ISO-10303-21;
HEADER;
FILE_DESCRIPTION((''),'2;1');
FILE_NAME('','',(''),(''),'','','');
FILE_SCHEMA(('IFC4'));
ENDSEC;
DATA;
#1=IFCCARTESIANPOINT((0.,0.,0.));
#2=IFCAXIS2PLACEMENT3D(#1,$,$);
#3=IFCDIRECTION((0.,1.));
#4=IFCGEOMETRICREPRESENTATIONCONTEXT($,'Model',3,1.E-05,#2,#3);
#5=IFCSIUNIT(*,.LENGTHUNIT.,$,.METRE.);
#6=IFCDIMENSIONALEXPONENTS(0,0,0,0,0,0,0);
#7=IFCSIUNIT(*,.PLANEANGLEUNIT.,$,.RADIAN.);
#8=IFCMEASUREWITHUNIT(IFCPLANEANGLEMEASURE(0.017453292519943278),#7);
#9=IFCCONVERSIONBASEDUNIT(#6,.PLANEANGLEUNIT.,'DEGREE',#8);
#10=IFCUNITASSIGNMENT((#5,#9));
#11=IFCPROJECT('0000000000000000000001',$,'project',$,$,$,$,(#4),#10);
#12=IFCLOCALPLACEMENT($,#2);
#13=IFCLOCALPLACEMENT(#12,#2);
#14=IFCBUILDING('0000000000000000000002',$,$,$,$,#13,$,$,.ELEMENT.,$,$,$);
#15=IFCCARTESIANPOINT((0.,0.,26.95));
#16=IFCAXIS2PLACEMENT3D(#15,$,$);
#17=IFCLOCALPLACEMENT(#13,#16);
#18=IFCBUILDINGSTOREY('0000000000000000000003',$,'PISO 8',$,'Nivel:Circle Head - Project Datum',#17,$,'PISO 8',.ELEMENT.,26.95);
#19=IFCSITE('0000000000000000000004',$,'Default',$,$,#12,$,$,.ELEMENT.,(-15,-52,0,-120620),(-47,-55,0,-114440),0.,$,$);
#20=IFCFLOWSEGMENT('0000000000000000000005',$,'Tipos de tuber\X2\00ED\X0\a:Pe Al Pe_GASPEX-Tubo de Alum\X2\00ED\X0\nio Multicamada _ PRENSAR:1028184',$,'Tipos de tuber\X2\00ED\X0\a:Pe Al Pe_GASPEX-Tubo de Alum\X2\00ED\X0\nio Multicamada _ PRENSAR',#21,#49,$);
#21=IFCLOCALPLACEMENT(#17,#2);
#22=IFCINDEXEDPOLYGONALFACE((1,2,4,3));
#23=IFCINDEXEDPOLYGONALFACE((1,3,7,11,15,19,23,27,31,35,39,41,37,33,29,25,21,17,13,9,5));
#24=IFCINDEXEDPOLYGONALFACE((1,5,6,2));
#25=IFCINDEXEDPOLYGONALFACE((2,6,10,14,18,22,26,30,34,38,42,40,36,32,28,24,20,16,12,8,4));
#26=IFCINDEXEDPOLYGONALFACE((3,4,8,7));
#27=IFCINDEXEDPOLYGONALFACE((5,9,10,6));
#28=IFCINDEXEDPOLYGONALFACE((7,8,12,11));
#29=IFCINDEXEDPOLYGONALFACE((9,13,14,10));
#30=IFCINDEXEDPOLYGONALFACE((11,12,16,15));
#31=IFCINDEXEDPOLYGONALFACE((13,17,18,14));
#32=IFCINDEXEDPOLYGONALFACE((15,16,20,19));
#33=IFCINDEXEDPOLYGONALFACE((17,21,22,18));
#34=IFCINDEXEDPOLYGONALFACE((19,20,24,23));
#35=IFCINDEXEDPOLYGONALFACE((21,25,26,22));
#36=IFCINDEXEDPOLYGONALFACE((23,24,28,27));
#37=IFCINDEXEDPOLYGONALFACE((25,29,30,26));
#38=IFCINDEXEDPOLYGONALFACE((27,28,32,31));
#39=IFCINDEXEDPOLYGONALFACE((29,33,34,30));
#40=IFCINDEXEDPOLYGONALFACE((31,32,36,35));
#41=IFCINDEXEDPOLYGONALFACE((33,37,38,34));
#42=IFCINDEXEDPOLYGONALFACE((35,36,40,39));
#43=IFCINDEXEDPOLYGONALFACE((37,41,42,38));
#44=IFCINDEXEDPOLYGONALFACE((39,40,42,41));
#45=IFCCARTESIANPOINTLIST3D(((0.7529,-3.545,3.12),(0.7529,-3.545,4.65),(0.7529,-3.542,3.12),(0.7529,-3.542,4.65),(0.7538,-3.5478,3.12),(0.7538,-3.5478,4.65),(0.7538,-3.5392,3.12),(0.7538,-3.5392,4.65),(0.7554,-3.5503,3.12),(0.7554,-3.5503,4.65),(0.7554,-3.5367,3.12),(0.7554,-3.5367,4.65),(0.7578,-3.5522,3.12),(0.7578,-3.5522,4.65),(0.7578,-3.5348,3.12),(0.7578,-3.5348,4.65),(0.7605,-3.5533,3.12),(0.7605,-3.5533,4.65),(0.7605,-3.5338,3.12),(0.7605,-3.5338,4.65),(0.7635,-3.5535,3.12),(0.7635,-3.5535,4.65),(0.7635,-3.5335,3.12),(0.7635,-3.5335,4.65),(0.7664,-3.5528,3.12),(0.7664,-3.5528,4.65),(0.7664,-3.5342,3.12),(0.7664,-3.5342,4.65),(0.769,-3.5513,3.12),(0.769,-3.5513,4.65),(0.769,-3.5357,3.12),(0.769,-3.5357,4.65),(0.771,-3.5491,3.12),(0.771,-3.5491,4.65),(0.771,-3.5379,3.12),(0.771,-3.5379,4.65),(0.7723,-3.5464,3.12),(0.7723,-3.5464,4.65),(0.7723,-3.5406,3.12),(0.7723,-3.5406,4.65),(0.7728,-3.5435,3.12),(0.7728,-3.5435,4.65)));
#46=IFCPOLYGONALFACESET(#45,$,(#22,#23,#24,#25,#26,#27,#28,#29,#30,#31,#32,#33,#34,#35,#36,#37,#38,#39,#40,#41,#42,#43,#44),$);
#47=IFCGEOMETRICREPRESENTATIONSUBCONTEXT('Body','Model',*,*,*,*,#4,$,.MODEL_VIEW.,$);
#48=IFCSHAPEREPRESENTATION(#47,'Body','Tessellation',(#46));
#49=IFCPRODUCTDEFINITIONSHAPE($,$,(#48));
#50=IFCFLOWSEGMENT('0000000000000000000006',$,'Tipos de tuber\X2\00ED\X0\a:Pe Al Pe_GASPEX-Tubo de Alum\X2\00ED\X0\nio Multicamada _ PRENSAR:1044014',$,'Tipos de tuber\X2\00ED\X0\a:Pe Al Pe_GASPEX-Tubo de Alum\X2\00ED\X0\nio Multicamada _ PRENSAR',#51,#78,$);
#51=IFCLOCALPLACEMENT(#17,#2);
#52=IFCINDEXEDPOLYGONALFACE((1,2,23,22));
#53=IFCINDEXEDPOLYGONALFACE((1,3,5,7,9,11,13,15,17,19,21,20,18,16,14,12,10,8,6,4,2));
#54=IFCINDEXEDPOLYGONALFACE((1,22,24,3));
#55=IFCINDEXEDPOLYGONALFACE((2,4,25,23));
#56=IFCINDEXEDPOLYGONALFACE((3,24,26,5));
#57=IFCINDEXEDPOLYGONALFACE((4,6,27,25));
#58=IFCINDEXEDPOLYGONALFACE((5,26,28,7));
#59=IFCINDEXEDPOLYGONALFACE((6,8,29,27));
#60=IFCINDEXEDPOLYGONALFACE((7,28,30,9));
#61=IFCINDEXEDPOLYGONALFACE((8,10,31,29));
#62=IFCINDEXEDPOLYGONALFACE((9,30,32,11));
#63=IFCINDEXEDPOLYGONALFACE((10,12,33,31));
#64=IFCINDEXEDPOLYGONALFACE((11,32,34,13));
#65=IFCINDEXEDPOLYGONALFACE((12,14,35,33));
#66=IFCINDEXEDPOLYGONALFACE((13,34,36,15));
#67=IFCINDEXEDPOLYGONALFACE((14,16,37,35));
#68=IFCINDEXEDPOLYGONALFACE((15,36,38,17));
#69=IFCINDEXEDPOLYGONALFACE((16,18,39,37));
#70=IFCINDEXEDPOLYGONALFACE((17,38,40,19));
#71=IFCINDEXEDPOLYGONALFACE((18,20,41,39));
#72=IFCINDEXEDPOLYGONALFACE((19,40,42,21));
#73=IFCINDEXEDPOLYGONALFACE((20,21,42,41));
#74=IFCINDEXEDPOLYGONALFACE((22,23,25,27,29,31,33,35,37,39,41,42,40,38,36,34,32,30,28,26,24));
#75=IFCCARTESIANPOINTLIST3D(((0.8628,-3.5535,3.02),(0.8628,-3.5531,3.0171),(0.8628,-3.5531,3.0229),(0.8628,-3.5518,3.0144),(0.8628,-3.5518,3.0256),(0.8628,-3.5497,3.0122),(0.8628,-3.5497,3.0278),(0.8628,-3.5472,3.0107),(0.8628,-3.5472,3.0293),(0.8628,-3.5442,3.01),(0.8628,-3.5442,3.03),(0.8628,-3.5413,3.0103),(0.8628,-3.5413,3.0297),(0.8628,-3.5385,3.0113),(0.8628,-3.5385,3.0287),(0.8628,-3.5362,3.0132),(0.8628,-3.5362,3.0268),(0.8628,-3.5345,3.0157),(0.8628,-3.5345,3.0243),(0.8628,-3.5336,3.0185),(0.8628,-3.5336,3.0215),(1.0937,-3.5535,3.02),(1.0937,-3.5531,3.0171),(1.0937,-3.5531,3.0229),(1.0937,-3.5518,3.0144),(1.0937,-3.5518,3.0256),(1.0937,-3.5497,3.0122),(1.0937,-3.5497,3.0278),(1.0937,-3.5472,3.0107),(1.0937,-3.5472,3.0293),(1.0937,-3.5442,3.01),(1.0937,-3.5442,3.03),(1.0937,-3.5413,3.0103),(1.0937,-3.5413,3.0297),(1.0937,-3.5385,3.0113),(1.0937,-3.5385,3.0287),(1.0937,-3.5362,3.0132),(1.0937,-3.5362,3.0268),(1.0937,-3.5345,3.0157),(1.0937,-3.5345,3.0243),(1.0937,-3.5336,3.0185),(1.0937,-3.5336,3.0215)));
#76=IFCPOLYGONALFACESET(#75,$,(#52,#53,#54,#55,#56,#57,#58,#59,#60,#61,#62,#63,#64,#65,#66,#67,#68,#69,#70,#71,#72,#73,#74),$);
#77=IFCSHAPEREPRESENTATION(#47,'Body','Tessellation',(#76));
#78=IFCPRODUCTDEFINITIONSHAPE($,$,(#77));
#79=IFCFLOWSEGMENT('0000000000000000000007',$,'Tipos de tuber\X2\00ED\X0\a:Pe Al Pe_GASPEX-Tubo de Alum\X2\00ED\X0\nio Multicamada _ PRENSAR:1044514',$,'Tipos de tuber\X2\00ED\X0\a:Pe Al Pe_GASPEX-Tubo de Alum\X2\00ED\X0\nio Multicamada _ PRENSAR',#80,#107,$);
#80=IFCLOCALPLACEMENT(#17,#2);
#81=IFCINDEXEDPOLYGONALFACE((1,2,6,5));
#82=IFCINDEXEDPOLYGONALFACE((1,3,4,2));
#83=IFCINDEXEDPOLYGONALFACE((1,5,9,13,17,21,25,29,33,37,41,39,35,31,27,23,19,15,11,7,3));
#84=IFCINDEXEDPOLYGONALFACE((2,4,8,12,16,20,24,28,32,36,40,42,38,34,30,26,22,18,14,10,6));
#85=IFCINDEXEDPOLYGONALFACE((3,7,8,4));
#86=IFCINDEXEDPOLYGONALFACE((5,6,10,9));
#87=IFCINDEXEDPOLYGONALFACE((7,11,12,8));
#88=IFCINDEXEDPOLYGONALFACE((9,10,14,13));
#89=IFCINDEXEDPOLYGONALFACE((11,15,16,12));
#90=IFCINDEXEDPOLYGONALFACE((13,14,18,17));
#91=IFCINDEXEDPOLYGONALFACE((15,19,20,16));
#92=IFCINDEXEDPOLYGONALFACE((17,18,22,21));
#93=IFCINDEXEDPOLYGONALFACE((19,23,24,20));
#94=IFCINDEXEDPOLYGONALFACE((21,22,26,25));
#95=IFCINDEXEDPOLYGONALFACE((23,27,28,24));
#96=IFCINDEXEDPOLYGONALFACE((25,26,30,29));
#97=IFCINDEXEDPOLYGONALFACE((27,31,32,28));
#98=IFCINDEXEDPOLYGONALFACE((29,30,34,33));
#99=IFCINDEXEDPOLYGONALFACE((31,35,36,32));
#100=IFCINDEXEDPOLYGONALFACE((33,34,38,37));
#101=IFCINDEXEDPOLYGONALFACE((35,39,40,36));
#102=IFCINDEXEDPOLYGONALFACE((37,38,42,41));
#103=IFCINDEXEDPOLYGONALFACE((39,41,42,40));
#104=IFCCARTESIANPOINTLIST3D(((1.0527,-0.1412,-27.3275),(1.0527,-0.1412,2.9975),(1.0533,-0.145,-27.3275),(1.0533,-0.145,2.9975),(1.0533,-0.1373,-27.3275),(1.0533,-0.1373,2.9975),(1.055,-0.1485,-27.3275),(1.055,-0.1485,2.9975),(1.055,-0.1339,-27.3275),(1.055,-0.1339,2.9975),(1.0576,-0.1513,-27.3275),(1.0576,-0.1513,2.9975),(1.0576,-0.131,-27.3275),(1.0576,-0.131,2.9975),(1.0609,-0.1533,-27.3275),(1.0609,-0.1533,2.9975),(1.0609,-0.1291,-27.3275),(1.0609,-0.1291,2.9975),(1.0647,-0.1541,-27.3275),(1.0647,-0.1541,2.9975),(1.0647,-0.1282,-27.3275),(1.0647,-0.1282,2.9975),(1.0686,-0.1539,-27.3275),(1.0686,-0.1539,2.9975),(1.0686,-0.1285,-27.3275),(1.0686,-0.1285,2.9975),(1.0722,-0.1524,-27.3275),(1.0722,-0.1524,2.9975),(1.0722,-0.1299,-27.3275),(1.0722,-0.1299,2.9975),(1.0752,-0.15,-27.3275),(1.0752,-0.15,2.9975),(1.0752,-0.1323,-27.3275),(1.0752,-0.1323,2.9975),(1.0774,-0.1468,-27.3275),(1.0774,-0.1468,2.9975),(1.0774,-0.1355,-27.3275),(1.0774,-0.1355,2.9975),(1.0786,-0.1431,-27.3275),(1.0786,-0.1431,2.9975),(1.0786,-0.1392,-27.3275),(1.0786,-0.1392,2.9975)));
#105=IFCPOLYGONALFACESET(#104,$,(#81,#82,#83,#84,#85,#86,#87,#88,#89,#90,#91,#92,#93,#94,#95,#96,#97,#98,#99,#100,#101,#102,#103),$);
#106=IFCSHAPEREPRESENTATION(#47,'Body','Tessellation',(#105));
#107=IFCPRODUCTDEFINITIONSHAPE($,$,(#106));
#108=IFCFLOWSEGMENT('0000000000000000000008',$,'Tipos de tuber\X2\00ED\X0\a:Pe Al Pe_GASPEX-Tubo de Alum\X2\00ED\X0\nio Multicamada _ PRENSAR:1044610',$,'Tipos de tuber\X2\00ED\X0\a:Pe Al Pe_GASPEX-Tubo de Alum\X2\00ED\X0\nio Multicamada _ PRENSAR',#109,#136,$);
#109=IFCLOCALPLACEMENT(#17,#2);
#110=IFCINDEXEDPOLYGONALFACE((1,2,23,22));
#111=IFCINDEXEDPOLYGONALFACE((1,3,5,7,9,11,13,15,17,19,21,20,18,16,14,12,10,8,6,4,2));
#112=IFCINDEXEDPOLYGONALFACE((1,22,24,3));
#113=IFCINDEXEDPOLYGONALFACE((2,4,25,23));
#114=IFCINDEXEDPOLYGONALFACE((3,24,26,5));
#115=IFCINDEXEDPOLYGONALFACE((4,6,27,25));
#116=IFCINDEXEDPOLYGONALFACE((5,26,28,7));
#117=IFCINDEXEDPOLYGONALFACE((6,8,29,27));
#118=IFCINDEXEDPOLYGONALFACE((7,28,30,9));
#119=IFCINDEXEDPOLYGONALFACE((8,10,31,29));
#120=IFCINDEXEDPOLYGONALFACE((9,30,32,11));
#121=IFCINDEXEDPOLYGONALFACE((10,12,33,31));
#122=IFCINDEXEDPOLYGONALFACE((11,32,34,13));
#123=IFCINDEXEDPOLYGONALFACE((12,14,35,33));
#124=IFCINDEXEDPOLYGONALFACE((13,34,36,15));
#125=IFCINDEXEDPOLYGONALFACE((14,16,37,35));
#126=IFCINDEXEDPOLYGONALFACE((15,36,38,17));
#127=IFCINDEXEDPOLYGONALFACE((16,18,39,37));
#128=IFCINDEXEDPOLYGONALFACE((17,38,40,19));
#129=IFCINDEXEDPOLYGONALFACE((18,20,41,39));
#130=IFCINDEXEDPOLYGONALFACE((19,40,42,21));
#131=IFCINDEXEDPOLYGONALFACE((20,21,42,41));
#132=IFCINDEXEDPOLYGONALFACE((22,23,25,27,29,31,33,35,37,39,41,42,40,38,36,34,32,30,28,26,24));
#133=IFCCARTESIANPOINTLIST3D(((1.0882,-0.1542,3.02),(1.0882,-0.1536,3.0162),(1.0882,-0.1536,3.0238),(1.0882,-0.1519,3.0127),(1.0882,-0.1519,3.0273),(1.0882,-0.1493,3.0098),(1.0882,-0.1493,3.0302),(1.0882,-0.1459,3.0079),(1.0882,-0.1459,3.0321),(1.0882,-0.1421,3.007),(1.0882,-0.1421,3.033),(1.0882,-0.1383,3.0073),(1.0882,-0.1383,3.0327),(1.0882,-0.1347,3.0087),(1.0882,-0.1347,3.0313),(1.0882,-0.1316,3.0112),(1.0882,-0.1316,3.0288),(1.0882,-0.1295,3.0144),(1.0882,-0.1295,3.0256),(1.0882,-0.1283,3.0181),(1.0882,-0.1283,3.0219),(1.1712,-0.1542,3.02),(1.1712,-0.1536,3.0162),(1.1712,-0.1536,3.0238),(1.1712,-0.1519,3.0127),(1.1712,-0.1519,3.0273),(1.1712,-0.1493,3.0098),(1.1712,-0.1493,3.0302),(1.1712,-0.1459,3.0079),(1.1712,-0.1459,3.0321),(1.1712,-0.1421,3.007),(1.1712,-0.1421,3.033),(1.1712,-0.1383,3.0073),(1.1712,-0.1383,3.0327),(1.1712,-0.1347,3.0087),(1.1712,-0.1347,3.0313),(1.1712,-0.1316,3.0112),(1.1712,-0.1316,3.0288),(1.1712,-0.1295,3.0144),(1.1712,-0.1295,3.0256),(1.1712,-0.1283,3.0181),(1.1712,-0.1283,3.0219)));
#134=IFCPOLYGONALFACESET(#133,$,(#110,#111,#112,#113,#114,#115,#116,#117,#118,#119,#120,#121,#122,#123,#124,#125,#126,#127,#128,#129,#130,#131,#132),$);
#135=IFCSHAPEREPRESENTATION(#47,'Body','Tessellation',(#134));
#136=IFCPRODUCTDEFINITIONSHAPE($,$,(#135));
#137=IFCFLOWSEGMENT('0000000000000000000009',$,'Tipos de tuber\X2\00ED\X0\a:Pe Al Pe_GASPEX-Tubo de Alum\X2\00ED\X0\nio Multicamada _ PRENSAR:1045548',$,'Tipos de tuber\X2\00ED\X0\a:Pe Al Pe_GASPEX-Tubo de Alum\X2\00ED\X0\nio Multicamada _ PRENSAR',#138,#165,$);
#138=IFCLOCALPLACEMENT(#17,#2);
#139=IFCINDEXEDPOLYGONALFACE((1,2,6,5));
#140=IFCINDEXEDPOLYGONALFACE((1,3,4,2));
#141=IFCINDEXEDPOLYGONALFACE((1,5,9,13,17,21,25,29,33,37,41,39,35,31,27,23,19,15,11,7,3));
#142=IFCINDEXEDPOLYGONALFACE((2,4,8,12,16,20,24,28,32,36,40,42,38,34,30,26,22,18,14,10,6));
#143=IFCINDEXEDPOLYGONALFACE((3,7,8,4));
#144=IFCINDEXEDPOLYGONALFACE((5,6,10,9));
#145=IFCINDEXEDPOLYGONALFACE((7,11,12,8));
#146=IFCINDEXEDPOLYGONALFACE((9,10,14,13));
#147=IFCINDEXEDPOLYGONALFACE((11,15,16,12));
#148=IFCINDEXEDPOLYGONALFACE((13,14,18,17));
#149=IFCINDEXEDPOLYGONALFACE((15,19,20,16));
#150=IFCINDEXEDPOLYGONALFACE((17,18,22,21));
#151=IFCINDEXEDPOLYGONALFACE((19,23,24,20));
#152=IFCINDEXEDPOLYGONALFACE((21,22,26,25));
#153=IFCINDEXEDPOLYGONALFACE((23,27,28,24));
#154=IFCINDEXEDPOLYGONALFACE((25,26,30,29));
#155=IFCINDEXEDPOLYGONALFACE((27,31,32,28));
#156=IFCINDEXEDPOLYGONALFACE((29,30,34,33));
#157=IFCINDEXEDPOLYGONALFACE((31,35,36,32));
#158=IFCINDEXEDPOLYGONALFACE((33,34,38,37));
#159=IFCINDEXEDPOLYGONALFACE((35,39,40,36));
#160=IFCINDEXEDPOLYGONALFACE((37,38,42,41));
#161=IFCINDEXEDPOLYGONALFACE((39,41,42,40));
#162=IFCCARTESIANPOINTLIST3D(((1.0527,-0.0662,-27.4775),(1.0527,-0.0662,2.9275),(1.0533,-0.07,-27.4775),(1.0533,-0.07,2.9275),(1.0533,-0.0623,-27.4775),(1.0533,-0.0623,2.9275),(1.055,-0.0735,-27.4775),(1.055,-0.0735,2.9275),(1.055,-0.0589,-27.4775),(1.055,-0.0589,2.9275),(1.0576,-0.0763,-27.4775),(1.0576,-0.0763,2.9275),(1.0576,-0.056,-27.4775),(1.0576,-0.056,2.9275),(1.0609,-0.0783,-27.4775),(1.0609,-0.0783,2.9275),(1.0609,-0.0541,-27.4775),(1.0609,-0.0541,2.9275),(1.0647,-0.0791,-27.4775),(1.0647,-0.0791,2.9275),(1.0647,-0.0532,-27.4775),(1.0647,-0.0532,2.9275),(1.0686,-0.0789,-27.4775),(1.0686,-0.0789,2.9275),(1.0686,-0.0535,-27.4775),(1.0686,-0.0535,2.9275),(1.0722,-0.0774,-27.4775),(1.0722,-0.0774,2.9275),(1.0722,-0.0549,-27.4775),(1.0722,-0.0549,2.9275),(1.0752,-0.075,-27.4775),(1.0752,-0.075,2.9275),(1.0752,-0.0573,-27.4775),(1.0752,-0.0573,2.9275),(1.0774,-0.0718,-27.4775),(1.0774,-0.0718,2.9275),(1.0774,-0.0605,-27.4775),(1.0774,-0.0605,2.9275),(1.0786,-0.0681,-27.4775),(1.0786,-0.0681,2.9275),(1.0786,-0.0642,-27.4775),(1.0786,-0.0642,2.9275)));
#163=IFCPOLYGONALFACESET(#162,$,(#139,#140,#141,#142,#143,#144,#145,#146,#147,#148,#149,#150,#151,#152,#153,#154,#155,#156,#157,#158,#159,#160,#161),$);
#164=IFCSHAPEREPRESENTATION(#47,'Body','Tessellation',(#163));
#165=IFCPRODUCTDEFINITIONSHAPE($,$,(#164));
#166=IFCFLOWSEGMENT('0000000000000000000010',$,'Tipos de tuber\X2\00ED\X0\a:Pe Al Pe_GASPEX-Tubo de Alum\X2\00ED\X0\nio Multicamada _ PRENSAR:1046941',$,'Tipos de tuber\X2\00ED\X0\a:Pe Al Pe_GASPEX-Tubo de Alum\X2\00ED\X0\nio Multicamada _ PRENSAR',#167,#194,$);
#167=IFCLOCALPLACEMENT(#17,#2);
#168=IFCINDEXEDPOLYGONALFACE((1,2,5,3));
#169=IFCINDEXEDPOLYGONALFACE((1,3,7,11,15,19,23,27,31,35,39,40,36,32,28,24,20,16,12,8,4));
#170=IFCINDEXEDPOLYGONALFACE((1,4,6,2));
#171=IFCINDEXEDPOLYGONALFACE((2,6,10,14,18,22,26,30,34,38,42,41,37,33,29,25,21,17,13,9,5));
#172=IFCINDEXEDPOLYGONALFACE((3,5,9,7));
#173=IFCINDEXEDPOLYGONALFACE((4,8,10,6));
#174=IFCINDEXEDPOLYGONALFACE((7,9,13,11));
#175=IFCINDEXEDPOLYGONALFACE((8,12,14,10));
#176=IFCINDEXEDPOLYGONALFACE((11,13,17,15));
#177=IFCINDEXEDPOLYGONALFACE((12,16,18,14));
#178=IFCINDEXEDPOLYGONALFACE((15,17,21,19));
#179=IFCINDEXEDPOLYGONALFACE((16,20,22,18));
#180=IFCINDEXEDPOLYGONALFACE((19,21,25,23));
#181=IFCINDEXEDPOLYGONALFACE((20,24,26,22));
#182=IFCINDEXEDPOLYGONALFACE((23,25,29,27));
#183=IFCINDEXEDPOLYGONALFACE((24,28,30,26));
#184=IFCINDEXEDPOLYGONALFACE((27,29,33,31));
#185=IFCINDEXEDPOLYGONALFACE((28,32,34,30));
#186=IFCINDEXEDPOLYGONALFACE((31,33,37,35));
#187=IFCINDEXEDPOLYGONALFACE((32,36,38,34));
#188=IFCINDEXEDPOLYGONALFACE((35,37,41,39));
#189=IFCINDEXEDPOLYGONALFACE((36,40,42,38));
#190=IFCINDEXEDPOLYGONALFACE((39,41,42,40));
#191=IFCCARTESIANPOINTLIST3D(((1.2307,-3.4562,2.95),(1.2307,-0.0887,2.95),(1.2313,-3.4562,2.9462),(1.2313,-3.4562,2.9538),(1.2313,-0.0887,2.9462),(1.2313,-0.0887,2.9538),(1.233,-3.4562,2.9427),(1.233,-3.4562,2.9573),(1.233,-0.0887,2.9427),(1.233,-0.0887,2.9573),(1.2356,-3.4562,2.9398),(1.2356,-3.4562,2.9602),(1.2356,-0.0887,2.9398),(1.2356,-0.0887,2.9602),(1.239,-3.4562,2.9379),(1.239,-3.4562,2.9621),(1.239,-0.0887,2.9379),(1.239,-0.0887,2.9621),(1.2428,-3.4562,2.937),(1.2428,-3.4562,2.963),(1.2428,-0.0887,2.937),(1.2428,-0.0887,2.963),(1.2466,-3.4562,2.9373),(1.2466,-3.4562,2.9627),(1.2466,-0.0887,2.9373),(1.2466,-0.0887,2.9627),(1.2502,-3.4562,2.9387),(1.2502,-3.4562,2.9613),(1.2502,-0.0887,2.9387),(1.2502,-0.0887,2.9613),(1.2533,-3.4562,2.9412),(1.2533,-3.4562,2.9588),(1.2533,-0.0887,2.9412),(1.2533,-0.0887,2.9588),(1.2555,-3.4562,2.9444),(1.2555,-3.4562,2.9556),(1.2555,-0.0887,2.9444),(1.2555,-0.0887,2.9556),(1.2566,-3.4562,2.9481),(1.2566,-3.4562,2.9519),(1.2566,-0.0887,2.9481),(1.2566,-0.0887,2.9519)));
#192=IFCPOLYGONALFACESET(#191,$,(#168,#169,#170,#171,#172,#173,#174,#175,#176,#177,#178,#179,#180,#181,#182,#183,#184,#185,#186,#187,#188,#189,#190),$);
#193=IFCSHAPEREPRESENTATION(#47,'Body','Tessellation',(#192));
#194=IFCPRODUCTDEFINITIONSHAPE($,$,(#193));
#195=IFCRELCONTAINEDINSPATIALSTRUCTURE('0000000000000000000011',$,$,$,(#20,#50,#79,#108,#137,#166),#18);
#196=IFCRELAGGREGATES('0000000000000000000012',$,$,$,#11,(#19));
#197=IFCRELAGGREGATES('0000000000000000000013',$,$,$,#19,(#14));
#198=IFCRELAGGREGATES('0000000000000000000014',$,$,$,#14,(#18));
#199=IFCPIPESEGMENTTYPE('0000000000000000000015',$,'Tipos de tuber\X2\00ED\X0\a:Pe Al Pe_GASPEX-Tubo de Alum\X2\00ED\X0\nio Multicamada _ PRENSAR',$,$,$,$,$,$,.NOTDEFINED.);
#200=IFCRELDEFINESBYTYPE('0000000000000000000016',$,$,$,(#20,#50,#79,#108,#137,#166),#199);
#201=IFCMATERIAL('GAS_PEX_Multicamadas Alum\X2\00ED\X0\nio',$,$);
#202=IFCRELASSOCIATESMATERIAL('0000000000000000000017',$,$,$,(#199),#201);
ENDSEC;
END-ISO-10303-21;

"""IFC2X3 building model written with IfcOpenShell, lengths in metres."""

from ifc_helpers import new_model, entity, si_unit, converted_unit, direction, frame, frame_2d, origin, origin_2d_with_axis, place, context, subcontext, project, spatial, circle, extrude, material, type_object, element, save


model = new_model("IFC2X3")

# Units and contexts
model_context = context("Model", 3, precision=1e-05, world=origin(), true_north=direction((0.0, 1.0)))
body_context = subcontext(model_context, "Body", "Model", "MODEL_VIEW")
ifc_project = project(units=[si_unit("LENGTHUNIT", "METRE"), converted_unit("PLANEANGLEUNIT", "DEGREE", entity("IfcPlaneAngleMeasure", 0.017453292519943278), si_unit("PLANEANGLEUNIT", "RADIAN"), dimensions=[0, 0, 0, 0, 0, 0, 0])], contexts=[model_context])

# Site, building, storey
site_placement = place(None, origin())
site = spatial("IfcSite", under=ifc_project, at=site_placement, Name="Default", CompositionType="ELEMENT", RefLatitude=(-15, -52, 0, -120620), RefLongitude=(-47, -55, 0, -114440), RefElevation=0.0)
building_placement = place(site_placement, origin())
building = spatial("IfcBuilding", under=site, at=building_placement, CompositionType="ELEMENT")
storey_placement = place(building_placement, frame((0.0, 0.0, 26.95)))
storey = spatial("IfcBuildingStorey", under=building, at=storey_placement, Name="PISO 8", ObjectType="Nivel:Circle Head - Project Datum", LongName="PISO 8", CompositionType="ELEMENT", Elevation=26.95)

# Flow segments
ifc_material = material(Name="GAS_PEX_Multicamadas Alumínio")
pipe_segment_type = type_object("IfcPipeSegmentType", Name="Tipos de tubería:Pe Al Pe_GASPEX-Tubo de Alumínio Multicamada _ PRENSAR", PredefinedType="NOTDEFINED", material=ifc_material)
flow_segment_1_placement = place(storey_placement, origin())
element("IfcFlowSegment", 1, at=flow_segment_1_placement, inside=storey, type_object=pipe_segment_type, Name="Tipos de tubería:Pe Al Pe_GASPEX-Tubo de Alumínio Multicamada _ PRENSAR:1028184", ObjectType="Tipos de tubería:Pe Al Pe_GASPEX-Tubo de Alumínio Multicamada _ PRENSAR", context=body_context, shape_type="SweptSolid", body=[
    extrude(circle(Radius=0.01, at=origin_2d_with_axis()), frame((0.7628, -3.5435, 3.12)), (0.0, 0.0, 1.0), 1.53),
])
flow_segment_2_placement = place(storey_placement, origin())
element("IfcFlowSegment", 2, at=flow_segment_2_placement, inside=storey, type_object=pipe_segment_type, Name="Tipos de tubería:Pe Al Pe_GASPEX-Tubo de Alumínio Multicamada _ PRENSAR:1044014", ObjectType="Tipos de tubería:Pe Al Pe_GASPEX-Tubo de Alumínio Multicamada _ PRENSAR", context=body_context, shape_type="SweptSolid", body=[
    extrude(circle(Radius=0.01, at=frame_2d((0.0, 0.0), x_axis=(1.0, 0.0))), frame((0.8628, -3.5435, 3.02), z_axis=(1.0, 0.0, 0.0), x_axis=(0.0, -1.0, 0.0)), (0.0, 0.0, 1.0), 0.231),
])
flow_segment_3_placement = place(storey_placement, origin())
element("IfcFlowSegment", 3, at=flow_segment_3_placement, inside=storey, type_object=pipe_segment_type, Name="Tipos de tubería:Pe Al Pe_GASPEX-Tubo de Alumínio Multicamada _ PRENSAR:1044514", ObjectType="Tipos de tubería:Pe Al Pe_GASPEX-Tubo de Alumínio Multicamada _ PRENSAR", context=body_context, shape_type="SweptSolid", body=[
    extrude(circle(Radius=0.013, at=frame_2d((0.0, 0.0), x_axis=(1.0, 0.0))), frame((1.0657, -0.1412, -27.3275), z_axis=(0.0, 0.0, 1.0), x_axis=(-1.0, 0.0, 0.0)), (0.0, 0.0, 1.0), 30.325),
])
flow_segment_4_placement = place(storey_placement, origin())
element("IfcFlowSegment", 4, at=flow_segment_4_placement, inside=storey, type_object=pipe_segment_type, Name="Tipos de tubería:Pe Al Pe_GASPEX-Tubo de Alumínio Multicamada _ PRENSAR:1044610", ObjectType="Tipos de tubería:Pe Al Pe_GASPEX-Tubo de Alumínio Multicamada _ PRENSAR", context=body_context, shape_type="SweptSolid", body=[
    extrude(circle(Radius=0.013, at=frame_2d((0.0, 0.0), x_axis=(1.0, 0.0))), frame((1.0882, -0.1412, 3.02), z_axis=(1.0, 0.0, 0.0), x_axis=(0.0, -1.0, 0.0)), (0.0, 0.0, 1.0), 0.083),
])
flow_segment_5_placement = place(storey_placement, origin())
element("IfcFlowSegment", 5, at=flow_segment_5_placement, inside=storey, type_object=pipe_segment_type, Name="Tipos de tubería:Pe Al Pe_GASPEX-Tubo de Alumínio Multicamada _ PRENSAR:1045548", ObjectType="Tipos de tubería:Pe Al Pe_GASPEX-Tubo de Alumínio Multicamada _ PRENSAR", context=body_context, shape_type="SweptSolid", body=[
    extrude(circle(Radius=0.013, at=frame_2d((0.0, 0.0), x_axis=(1.0, 0.0))), frame((1.0657, -0.0662, -27.4775), z_axis=(0.0, 0.0, 1.0), x_axis=(-1.0, 0.0, 0.0)), (0.0, 0.0, 1.0), 30.405),
])
flow_segment_6_placement = place(storey_placement, origin())
element("IfcFlowSegment", 6, at=flow_segment_6_placement, inside=storey, type_object=pipe_segment_type, Name="Tipos de tubería:Pe Al Pe_GASPEX-Tubo de Alumínio Multicamada _ PRENSAR:1046941", ObjectType="Tipos de tubería:Pe Al Pe_GASPEX-Tubo de Alumínio Multicamada _ PRENSAR", context=body_context, shape_type="SweptSolid", body=[
    extrude(circle(Radius=0.013, at=frame_2d((0.0, 0.0), x_axis=(1.0, 0.0))), frame((1.2437, -3.4562, 2.95), z_axis=(0.0, 1.0, 0.0), x_axis=(-1.0, 0.0, 0.0)), (0.0, 0.0, 1.0), 3.3675),
])

save(model, "model.ifc")
